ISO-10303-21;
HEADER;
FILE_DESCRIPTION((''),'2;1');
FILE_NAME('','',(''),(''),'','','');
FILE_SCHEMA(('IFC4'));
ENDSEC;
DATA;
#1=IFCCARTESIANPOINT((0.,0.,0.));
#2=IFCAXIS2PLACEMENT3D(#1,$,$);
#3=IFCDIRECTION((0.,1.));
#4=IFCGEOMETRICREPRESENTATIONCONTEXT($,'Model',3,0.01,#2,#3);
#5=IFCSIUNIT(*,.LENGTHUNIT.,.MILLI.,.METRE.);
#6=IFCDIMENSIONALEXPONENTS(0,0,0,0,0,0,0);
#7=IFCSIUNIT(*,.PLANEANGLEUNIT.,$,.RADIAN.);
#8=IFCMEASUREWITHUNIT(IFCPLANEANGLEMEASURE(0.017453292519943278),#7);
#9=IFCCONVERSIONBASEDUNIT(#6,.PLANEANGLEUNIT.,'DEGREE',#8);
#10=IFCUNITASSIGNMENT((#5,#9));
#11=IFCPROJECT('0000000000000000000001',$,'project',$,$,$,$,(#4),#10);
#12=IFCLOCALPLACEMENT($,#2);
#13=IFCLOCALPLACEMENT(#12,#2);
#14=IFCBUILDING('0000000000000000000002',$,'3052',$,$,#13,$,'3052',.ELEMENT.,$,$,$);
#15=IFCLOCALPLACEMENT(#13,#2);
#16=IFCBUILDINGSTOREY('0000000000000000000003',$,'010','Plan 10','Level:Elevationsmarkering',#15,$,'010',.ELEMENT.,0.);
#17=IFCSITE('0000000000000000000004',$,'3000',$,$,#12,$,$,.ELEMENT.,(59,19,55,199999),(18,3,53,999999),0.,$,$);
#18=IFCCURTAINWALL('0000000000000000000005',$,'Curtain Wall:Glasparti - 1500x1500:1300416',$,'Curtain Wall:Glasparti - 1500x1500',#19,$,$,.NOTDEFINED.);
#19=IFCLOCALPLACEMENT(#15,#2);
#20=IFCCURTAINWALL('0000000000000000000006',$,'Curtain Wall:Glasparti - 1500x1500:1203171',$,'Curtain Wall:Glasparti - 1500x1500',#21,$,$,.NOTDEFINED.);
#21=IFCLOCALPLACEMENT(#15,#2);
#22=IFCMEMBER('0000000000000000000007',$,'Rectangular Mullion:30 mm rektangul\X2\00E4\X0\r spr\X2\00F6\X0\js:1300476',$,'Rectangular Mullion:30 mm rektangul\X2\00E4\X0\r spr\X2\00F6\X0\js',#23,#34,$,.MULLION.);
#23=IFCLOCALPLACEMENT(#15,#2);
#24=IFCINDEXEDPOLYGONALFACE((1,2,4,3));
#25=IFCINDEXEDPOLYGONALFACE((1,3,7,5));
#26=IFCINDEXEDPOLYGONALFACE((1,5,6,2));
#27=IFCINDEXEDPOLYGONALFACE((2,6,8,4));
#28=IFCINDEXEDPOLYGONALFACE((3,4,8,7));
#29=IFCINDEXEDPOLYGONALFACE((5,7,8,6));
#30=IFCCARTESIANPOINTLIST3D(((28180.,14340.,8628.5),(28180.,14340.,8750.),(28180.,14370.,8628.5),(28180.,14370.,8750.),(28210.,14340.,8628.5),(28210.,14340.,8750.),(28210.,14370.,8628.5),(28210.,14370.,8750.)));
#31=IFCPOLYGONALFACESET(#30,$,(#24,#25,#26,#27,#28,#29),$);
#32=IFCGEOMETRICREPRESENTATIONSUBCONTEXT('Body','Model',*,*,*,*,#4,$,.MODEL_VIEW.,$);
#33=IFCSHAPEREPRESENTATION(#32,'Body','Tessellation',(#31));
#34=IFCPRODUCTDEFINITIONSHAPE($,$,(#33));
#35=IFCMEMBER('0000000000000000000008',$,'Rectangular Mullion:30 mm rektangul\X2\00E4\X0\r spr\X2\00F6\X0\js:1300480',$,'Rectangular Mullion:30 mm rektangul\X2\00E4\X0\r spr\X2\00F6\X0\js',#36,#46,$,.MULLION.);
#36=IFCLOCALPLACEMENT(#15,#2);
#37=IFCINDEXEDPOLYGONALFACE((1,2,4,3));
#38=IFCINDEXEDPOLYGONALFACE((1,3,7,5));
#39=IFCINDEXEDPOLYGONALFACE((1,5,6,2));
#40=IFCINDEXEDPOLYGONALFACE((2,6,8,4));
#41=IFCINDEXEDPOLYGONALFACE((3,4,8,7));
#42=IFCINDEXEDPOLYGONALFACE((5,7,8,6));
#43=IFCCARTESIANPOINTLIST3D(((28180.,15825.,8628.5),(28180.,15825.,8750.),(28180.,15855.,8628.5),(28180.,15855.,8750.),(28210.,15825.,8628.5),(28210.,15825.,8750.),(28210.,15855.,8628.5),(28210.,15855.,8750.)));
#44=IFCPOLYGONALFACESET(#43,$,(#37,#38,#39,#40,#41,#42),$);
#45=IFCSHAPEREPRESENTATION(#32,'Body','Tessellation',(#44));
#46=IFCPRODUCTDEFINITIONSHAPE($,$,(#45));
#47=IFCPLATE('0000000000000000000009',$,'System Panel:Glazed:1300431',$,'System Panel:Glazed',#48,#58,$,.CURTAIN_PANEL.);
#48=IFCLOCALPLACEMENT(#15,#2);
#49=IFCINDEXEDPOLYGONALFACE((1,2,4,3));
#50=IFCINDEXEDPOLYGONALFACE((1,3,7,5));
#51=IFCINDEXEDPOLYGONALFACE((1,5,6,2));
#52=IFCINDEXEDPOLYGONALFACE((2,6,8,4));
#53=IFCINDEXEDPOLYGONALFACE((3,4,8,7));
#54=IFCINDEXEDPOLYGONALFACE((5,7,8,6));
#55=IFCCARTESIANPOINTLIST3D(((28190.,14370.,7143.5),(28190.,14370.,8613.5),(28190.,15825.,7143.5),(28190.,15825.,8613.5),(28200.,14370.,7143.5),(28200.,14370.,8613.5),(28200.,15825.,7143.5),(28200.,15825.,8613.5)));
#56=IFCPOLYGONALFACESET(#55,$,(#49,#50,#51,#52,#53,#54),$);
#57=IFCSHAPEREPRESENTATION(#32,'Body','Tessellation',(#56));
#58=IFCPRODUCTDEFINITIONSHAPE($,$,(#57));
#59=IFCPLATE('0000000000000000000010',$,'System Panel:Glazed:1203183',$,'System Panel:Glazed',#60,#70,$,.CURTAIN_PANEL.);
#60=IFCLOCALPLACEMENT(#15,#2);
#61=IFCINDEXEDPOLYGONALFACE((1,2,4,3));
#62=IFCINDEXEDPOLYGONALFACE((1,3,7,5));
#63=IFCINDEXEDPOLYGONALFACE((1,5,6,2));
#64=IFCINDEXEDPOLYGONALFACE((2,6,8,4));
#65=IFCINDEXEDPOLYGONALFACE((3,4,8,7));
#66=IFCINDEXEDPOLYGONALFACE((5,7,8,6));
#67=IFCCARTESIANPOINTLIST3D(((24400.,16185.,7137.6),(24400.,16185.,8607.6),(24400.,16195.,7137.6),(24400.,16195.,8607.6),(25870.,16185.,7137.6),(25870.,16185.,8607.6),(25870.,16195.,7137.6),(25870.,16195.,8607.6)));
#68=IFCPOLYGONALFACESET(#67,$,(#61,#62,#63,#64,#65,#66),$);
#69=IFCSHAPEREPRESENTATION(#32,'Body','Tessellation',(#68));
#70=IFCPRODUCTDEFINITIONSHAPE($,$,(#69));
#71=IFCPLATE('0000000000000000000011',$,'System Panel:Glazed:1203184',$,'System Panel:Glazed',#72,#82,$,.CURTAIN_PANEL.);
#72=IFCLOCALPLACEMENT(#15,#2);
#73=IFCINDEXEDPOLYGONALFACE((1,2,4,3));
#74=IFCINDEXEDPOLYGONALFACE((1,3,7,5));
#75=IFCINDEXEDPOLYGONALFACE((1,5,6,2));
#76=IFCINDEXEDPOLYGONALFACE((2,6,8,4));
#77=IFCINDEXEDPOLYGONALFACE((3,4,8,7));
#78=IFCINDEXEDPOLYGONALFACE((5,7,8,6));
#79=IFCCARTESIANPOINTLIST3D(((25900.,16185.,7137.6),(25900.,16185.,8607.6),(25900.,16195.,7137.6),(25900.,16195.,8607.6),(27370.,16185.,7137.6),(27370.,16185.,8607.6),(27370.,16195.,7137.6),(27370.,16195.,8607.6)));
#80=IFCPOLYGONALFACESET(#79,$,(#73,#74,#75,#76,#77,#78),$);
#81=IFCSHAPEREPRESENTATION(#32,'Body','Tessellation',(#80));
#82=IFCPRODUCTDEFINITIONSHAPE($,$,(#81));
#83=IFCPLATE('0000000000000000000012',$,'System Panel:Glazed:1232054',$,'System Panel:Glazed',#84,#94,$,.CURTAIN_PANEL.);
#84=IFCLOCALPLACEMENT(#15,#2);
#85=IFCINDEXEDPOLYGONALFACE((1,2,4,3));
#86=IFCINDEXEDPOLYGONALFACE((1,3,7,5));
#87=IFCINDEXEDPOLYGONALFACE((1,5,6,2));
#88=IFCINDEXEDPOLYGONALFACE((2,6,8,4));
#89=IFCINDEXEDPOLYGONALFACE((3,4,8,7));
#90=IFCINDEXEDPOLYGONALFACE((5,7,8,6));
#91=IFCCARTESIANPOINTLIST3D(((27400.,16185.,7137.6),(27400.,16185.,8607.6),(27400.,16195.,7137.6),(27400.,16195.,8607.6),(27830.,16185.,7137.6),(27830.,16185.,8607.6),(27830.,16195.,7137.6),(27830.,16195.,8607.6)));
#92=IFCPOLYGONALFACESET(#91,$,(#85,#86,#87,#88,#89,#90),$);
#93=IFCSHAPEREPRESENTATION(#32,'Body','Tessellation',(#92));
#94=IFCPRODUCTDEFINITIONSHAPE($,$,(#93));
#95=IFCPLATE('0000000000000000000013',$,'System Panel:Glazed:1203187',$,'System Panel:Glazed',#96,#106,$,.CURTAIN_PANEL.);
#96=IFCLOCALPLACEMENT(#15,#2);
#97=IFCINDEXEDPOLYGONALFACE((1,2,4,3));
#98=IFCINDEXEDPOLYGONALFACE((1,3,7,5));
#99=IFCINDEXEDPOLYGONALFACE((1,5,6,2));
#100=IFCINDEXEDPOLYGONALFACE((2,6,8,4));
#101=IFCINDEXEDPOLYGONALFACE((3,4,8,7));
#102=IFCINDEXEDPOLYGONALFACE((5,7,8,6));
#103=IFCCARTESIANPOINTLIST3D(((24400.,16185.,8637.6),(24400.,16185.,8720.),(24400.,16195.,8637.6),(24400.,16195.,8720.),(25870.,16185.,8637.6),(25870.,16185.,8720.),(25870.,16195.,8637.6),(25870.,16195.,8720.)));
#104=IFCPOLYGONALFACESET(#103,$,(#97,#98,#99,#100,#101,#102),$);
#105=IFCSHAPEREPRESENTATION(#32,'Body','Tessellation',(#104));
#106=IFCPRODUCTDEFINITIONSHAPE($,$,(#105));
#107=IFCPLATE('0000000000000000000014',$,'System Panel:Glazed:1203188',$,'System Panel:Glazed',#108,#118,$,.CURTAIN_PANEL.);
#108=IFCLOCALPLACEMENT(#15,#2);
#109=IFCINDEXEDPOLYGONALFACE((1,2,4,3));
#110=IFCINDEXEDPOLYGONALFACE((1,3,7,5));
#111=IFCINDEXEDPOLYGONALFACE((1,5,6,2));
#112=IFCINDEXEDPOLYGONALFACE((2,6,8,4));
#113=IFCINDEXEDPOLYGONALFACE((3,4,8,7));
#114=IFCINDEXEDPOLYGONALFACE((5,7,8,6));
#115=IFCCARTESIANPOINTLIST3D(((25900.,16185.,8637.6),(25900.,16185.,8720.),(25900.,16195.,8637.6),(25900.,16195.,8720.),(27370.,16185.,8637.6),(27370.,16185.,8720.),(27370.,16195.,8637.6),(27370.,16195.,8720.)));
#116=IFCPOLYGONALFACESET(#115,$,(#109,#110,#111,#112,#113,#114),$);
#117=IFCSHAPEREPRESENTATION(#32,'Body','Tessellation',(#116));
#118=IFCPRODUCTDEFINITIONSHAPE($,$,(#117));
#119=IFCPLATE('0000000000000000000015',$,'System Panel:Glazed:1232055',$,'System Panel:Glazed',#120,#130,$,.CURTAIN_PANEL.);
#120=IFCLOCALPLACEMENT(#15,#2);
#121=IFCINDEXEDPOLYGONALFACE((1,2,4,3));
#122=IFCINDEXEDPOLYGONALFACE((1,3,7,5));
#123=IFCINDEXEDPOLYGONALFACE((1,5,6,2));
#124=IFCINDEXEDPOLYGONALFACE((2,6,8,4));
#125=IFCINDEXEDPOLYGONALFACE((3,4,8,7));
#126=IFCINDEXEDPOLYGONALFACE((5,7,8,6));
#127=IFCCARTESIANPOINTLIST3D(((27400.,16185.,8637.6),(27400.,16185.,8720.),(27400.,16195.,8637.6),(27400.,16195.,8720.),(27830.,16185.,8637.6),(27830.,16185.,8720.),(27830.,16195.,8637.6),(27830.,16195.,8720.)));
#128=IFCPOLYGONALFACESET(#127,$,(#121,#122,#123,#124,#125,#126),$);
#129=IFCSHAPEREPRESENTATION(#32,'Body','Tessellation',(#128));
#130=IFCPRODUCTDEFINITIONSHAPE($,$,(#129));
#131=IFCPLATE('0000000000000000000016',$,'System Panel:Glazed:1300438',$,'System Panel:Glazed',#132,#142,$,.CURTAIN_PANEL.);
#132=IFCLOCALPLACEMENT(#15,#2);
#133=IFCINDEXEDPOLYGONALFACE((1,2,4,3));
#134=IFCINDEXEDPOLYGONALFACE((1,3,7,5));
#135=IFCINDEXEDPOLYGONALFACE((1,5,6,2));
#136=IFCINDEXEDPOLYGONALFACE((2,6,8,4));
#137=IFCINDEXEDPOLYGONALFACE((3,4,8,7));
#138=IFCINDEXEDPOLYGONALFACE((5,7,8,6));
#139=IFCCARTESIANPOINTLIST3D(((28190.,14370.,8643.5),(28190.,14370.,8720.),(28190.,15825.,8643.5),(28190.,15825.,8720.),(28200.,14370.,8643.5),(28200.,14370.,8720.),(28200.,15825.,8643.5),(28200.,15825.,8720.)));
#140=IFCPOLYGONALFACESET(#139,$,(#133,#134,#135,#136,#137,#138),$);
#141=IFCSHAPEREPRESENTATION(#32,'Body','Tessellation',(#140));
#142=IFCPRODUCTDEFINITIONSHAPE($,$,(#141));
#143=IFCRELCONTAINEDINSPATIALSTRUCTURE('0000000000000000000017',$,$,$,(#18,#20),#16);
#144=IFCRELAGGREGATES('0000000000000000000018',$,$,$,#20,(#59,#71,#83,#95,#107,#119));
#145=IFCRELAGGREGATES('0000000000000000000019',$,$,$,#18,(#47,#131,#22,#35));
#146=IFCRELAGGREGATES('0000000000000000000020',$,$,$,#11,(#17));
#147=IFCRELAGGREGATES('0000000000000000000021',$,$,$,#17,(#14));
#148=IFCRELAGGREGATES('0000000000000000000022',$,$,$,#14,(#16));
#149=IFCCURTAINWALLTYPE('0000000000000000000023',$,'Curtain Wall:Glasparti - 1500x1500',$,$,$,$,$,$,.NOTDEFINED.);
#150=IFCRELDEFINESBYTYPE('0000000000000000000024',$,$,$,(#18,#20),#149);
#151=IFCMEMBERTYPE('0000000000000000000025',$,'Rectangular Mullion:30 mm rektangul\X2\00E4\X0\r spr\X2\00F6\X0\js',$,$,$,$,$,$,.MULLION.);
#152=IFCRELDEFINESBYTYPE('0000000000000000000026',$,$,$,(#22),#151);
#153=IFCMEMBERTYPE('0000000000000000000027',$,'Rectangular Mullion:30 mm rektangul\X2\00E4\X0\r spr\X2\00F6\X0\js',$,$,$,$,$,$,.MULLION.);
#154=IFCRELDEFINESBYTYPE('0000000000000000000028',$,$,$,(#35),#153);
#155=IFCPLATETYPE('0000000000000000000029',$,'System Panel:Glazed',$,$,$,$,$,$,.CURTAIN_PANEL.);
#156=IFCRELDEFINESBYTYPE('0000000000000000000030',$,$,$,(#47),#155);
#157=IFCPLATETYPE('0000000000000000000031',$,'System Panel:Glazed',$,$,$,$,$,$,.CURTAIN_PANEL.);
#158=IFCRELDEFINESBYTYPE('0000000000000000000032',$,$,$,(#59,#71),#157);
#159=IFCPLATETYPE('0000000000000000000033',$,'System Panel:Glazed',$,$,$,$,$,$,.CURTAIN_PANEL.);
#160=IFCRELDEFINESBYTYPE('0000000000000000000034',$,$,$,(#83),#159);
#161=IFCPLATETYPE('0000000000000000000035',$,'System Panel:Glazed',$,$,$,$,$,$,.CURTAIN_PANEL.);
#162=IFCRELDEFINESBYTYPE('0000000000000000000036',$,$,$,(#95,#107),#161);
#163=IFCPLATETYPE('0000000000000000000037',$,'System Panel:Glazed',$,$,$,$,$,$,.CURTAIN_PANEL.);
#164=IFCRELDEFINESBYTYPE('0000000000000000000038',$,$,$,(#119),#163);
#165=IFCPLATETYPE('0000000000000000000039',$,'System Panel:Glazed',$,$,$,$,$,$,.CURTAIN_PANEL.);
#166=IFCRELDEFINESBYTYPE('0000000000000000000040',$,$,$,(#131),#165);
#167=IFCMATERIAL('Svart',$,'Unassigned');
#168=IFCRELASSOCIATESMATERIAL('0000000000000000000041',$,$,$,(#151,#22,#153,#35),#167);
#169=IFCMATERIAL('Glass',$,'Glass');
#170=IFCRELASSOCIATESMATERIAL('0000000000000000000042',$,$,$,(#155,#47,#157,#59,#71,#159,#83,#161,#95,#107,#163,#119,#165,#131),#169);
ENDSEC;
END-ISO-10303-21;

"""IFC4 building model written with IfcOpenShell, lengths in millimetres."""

from ifc_helpers import new_model, entity, si_unit, converted_unit, direction, frame, origin, place, context, subcontext, project, spatial, indexed_curve, outline, extrude, source, transform, mapped, material, type_object, type_shapes, element, aggregate, save


model = new_model("IFC4")

# Units and contexts
model_context = context("Model", 3, precision=0.01, world=origin(), true_north=direction((0.0, 1.0)))
body_context = subcontext(model_context, "Body", "Model", "MODEL_VIEW")
ifc_project = project(units=[si_unit("LENGTHUNIT", "METRE", prefix="MILLI"), converted_unit("PLANEANGLEUNIT", "DEGREE", entity("IfcPlaneAngleMeasure", 0.017453292519943278), si_unit("PLANEANGLEUNIT", "RADIAN"), dimensions=[0, 0, 0, 0, 0, 0, 0])], contexts=[model_context])

# Site, building, storey
site_placement = place(None, origin())
site = spatial("IfcSite", under=ifc_project, at=site_placement, Name="3000", CompositionType="ELEMENT", RefLatitude=(59, 19, 55, 199999), RefLongitude=(18, 3, 53, 999999), RefElevation=0.0)
building_placement = place(site_placement, origin())
building = spatial("IfcBuilding", under=site, at=building_placement, Name="3052", LongName="3052", CompositionType="ELEMENT")
storey_placement = place(building_placement, origin())
storey = spatial("IfcBuildingStorey", under=building, at=storey_placement, Name="010", Description="Plan 10", ObjectType="Level:Elevationsmarkering", LongName="010", CompositionType="ELEMENT", Elevation=0.0)

# Curtain wall
curtain_wall_type = type_object("IfcCurtainWallType", Name="Curtain Wall:Glasparti - 1500x1500", PredefinedType="NOTDEFINED")
curtain_wall_1_placement = place(storey_placement, origin())
curtain_wall_1 = element("IfcCurtainWall", 1, at=curtain_wall_1_placement, inside=storey, type_object=curtain_wall_type, Name="Curtain Wall:Glasparti - 1500x1500:1300416", ObjectType="Curtain Wall:Glasparti - 1500x1500", PredefinedType="NOTDEFINED")
ifc_material_1 = material(Name="Svart", Category="Unassigned")

# Curtain wall
curtain_wall_2_placement = place(storey_placement, origin())
curtain_wall_2 = element("IfcCurtainWall", 2, at=curtain_wall_2_placement, inside=storey, type_object=curtain_wall_type, Name="Curtain Wall:Glasparti - 1500x1500:1203171", ObjectType="Curtain Wall:Glasparti - 1500x1500", PredefinedType="NOTDEFINED")

# Members
member_type_1 = type_object("IfcMemberType", Name="Rectangular Mullion:30 mm rektangulär spröjs", PredefinedType="MULLION", material=ifc_material_1)
shared_shape_1 = source(origin(), body_context, "Body", "SweptSolid", [
    extrude(outline(indexed_curve([(-15.0, -15.0), (15.0, -15.0), (15.0, 15.0), (-15.0, 15.0), (-15.0, -15.0)], self_intersect=False)), frame((0.0, 0.0, -121.5), z_axis=(0.0, 0.0, 1.0), x_axis=(-1.0, 0.0, 0.0)), (0.0, 0.0, 1.0), 121.5),
])
type_shapes(member_type_1, [shared_shape_1])
member_1_placement = place(curtain_wall_1_placement, frame((28195.0, 14355.0, 8628.5), z_axis=(0.0, 0.0, -1.0), x_axis=(0.0, -1.0, 0.0)))
member_1 = element("IfcMember", 3, at=member_1_placement, type_object=member_type_1, material=ifc_material_1, Name="Rectangular Mullion:30 mm rektangulär spröjs:1300476", ObjectType="Rectangular Mullion:30 mm rektangulär spröjs", PredefinedType="MULLION", context=body_context, shape_type="MappedRepresentation", body=[
    mapped(shared_shape_1, transform((0.0, 0.0, 0.0), scale=1.0)),
])
member_type_2 = type_object("IfcMemberType", Name="Rectangular Mullion:30 mm rektangulär spröjs", PredefinedType="MULLION", material=ifc_material_1)
shared_shape_2 = source(origin(), body_context, "Body", "SweptSolid", [
    extrude(outline(indexed_curve([(-15.0, -15.0), (15.0, -15.0), (15.0, 15.0), (-15.0, 15.0), (-15.0, -15.0)], self_intersect=False)), frame((-15.0, 0.0, -121.5), z_axis=(0.0, 0.0, 1.0), x_axis=(-1.0, 0.0, 0.0)), (0.0, 0.0, 1.0), 121.5),
])
type_shapes(member_type_2, [shared_shape_2])
member_2_placement = place(curtain_wall_1_placement, frame((28195.0, 15855.0, 8750.0), z_axis=(0.0, 0.0, 1.0), x_axis=(0.0, 1.0, 0.0)))
member_2 = element("IfcMember", 4, at=member_2_placement, type_object=member_type_2, material=ifc_material_1, Name="Rectangular Mullion:30 mm rektangulär spröjs:1300480", ObjectType="Rectangular Mullion:30 mm rektangulär spröjs", PredefinedType="MULLION", context=body_context, shape_type="MappedRepresentation", body=[
    mapped(shared_shape_2, transform((0.0, 0.0, 0.0), scale=1.0)),
])

# Plates
ifc_material_2 = material(Name="Glass", Category="Glass")
plate_type_1 = type_object("IfcPlateType", Name="System Panel:Glazed", PredefinedType="CURTAIN_PANEL", material=ifc_material_2)
shared_shape_3 = source(origin(), body_context, "Body", "SweptSolid", [
    extrude(outline(indexed_curve([(-5.0, -727.5), (5.0, -727.5), (5.0, 727.5), (-5.0, 727.5), (-5.0, -727.5)], self_intersect=False)), frame((0.0, 0.0, 0.0), z_axis=(0.0, 0.0, 1.0), x_axis=(0.0, 1.0, 0.0)), (0.0, 0.0, 1.0), 1470.0),
])
type_shapes(plate_type_1, [shared_shape_3])
plate_1_placement = place(curtain_wall_1_placement, frame((28195.0, 15097.5, 7143.5), z_axis=(0.0, 0.0, 1.0), x_axis=(0.0, -1.0, 0.0)))
plate_1 = element("IfcPlate", 5, at=plate_1_placement, type_object=plate_type_1, material=ifc_material_2, Name="System Panel:Glazed:1300431", ObjectType="System Panel:Glazed", PredefinedType="CURTAIN_PANEL", context=body_context, shape_type="MappedRepresentation", body=[
    mapped(shared_shape_3, transform((0.0, 0.0, 0.0), scale=1.0)),
])
plate_type_2 = type_object("IfcPlateType", Name="System Panel:Glazed", PredefinedType="CURTAIN_PANEL", material=ifc_material_2)
shared_shape_4 = source(origin(), body_context, "Body", "SweptSolid", [
    extrude(outline(indexed_curve([(-5.0, -735.0), (5.0, -735.0), (5.0, 735.0), (-5.0, 735.0), (-5.0, -735.0)], self_intersect=False)), frame((0.0, 0.0, 0.0), z_axis=(0.0, 0.0, 1.0), x_axis=(0.0, 1.0, 0.0)), (0.0, 0.0, 1.0), 1470.0),
])
type_shapes(plate_type_2, [shared_shape_4])
plate_2_placement = place(curtain_wall_2_placement, frame((25135.0, 16190.0, 7137.6)))
plate_2 = element("IfcPlate", 6, at=plate_2_placement, type_object=plate_type_2, material=ifc_material_2, Name="System Panel:Glazed:1203183", ObjectType="System Panel:Glazed", PredefinedType="CURTAIN_PANEL", context=body_context, shape_type="MappedRepresentation", body=[
    mapped(shared_shape_4, transform((0.0, 0.0, 0.0), scale=1.0)),
])
plate_3_placement = place(curtain_wall_2_placement, frame((26635.0, 16190.0, 7137.6)))
plate_3 = element("IfcPlate", 7, at=plate_3_placement, type_object=plate_type_2, material=ifc_material_2, Name="System Panel:Glazed:1203184", ObjectType="System Panel:Glazed", PredefinedType="CURTAIN_PANEL", context=body_context, shape_type="MappedRepresentation", body=[
    mapped(shared_shape_4, transform((0.0, 0.0, 0.0), scale=1.0)),
])
plate_type_3 = type_object("IfcPlateType", Name="System Panel:Glazed", PredefinedType="CURTAIN_PANEL", material=ifc_material_2)
shared_shape_5 = source(origin(), body_context, "Body", "SweptSolid", [
    extrude(outline(indexed_curve([(-5.0, -215.0), (5.0, -215.0), (5.0, 215.0), (-5.0, 215.0), (-5.0, -215.0)], self_intersect=False)), frame((0.0, 0.0, 0.0), z_axis=(0.0, 0.0, 1.0), x_axis=(0.0, 1.0, 0.0)), (0.0, 0.0, 1.0), 1470.0),
])
type_shapes(plate_type_3, [shared_shape_5])
plate_4_placement = place(curtain_wall_2_placement, frame((27615.0, 16190.0, 7137.6)))
plate_4 = element("IfcPlate", 8, at=plate_4_placement, type_object=plate_type_3, material=ifc_material_2, Name="System Panel:Glazed:1232054", ObjectType="System Panel:Glazed", PredefinedType="CURTAIN_PANEL", context=body_context, shape_type="MappedRepresentation", body=[
    mapped(shared_shape_5, transform((0.0, 0.0, 0.0), scale=1.0)),
])
plate_type_4 = type_object("IfcPlateType", Name="System Panel:Glazed", PredefinedType="CURTAIN_PANEL", material=ifc_material_2)
shared_shape_6 = source(origin(), body_context, "Body", "SweptSolid", [
    extrude(outline(indexed_curve([(-5.0, -735.0), (5.0, -735.0), (5.0, 735.0), (-5.0, 735.0), (-5.0, -735.0)], self_intersect=False)), frame((0.0, 0.0, 0.0), z_axis=(0.0, 0.0, 1.0), x_axis=(0.0, 1.0, 0.0)), (0.0, 0.0, 1.0), 82.4),
])
type_shapes(plate_type_4, [shared_shape_6])
plate_5_placement = place(curtain_wall_2_placement, frame((25135.0, 16190.0, 8637.6)))
plate_5 = element("IfcPlate", 9, at=plate_5_placement, type_object=plate_type_4, material=ifc_material_2, Name="System Panel:Glazed:1203187", ObjectType="System Panel:Glazed", PredefinedType="CURTAIN_PANEL", context=body_context, shape_type="MappedRepresentation", body=[
    mapped(shared_shape_6, transform((0.0, 0.0, 0.0), scale=1.0)),
])
plate_6_placement = place(curtain_wall_2_placement, frame((26635.0, 16190.0, 8637.6)))
plate_6 = element("IfcPlate", 10, at=plate_6_placement, type_object=plate_type_4, material=ifc_material_2, Name="System Panel:Glazed:1203188", ObjectType="System Panel:Glazed", PredefinedType="CURTAIN_PANEL", context=body_context, shape_type="MappedRepresentation", body=[
    mapped(shared_shape_6, transform((0.0, 0.0, 0.0), scale=1.0)),
])
plate_type_5 = type_object("IfcPlateType", Name="System Panel:Glazed", PredefinedType="CURTAIN_PANEL", material=ifc_material_2)
shared_shape_7 = source(origin(), body_context, "Body", "SweptSolid", [
    extrude(outline(indexed_curve([(-5.0, -215.0), (5.0, -215.0), (5.0, 215.0), (-5.0, 215.0), (-5.0, -215.0)], self_intersect=False)), frame((0.0, 0.0, 0.0), z_axis=(0.0, 0.0, 1.0), x_axis=(0.0, 1.0, 0.0)), (0.0, 0.0, 1.0), 82.4),
])
type_shapes(plate_type_5, [shared_shape_7])
plate_7_placement = place(curtain_wall_2_placement, frame((27615.0, 16190.0, 8637.6)))
plate_7 = element("IfcPlate", 11, at=plate_7_placement, type_object=plate_type_5, material=ifc_material_2, Name="System Panel:Glazed:1232055", ObjectType="System Panel:Glazed", PredefinedType="CURTAIN_PANEL", context=body_context, shape_type="MappedRepresentation", body=[
    mapped(shared_shape_7, transform((0.0, 0.0, 0.0), scale=1.0)),
])
aggregate(curtain_wall_2, [plate_2, plate_3, plate_4, plate_5, plate_6, plate_7])
plate_type_6 = type_object("IfcPlateType", Name="System Panel:Glazed", PredefinedType="CURTAIN_PANEL", material=ifc_material_2)
shared_shape_8 = source(origin(), body_context, "Body", "SweptSolid", [
    extrude(outline(indexed_curve([(-5.0, -727.5), (5.0, -727.5), (5.0, 727.5), (-5.0, 727.5), (-5.0, -727.5)], self_intersect=False)), frame((0.0, 0.0, 0.0), z_axis=(0.0, 0.0, 1.0), x_axis=(0.0, 1.0, 0.0)), (0.0, 0.0, 1.0), 76.5),
])
type_shapes(plate_type_6, [shared_shape_8])
plate_8_placement = place(curtain_wall_1_placement, frame((28195.0, 15097.5, 8643.5), z_axis=(0.0, 0.0, 1.0), x_axis=(0.0, -1.0, 0.0)))
plate_8 = element("IfcPlate", 12, at=plate_8_placement, type_object=plate_type_6, material=ifc_material_2, Name="System Panel:Glazed:1300438", ObjectType="System Panel:Glazed", PredefinedType="CURTAIN_PANEL", context=body_context, shape_type="MappedRepresentation", body=[
    mapped(shared_shape_8, transform((0.0, 0.0, 0.0), scale=1.0)),
])
aggregate(curtain_wall_1, [plate_1, plate_8, member_1, member_2])

save(model, "model.ifc")
